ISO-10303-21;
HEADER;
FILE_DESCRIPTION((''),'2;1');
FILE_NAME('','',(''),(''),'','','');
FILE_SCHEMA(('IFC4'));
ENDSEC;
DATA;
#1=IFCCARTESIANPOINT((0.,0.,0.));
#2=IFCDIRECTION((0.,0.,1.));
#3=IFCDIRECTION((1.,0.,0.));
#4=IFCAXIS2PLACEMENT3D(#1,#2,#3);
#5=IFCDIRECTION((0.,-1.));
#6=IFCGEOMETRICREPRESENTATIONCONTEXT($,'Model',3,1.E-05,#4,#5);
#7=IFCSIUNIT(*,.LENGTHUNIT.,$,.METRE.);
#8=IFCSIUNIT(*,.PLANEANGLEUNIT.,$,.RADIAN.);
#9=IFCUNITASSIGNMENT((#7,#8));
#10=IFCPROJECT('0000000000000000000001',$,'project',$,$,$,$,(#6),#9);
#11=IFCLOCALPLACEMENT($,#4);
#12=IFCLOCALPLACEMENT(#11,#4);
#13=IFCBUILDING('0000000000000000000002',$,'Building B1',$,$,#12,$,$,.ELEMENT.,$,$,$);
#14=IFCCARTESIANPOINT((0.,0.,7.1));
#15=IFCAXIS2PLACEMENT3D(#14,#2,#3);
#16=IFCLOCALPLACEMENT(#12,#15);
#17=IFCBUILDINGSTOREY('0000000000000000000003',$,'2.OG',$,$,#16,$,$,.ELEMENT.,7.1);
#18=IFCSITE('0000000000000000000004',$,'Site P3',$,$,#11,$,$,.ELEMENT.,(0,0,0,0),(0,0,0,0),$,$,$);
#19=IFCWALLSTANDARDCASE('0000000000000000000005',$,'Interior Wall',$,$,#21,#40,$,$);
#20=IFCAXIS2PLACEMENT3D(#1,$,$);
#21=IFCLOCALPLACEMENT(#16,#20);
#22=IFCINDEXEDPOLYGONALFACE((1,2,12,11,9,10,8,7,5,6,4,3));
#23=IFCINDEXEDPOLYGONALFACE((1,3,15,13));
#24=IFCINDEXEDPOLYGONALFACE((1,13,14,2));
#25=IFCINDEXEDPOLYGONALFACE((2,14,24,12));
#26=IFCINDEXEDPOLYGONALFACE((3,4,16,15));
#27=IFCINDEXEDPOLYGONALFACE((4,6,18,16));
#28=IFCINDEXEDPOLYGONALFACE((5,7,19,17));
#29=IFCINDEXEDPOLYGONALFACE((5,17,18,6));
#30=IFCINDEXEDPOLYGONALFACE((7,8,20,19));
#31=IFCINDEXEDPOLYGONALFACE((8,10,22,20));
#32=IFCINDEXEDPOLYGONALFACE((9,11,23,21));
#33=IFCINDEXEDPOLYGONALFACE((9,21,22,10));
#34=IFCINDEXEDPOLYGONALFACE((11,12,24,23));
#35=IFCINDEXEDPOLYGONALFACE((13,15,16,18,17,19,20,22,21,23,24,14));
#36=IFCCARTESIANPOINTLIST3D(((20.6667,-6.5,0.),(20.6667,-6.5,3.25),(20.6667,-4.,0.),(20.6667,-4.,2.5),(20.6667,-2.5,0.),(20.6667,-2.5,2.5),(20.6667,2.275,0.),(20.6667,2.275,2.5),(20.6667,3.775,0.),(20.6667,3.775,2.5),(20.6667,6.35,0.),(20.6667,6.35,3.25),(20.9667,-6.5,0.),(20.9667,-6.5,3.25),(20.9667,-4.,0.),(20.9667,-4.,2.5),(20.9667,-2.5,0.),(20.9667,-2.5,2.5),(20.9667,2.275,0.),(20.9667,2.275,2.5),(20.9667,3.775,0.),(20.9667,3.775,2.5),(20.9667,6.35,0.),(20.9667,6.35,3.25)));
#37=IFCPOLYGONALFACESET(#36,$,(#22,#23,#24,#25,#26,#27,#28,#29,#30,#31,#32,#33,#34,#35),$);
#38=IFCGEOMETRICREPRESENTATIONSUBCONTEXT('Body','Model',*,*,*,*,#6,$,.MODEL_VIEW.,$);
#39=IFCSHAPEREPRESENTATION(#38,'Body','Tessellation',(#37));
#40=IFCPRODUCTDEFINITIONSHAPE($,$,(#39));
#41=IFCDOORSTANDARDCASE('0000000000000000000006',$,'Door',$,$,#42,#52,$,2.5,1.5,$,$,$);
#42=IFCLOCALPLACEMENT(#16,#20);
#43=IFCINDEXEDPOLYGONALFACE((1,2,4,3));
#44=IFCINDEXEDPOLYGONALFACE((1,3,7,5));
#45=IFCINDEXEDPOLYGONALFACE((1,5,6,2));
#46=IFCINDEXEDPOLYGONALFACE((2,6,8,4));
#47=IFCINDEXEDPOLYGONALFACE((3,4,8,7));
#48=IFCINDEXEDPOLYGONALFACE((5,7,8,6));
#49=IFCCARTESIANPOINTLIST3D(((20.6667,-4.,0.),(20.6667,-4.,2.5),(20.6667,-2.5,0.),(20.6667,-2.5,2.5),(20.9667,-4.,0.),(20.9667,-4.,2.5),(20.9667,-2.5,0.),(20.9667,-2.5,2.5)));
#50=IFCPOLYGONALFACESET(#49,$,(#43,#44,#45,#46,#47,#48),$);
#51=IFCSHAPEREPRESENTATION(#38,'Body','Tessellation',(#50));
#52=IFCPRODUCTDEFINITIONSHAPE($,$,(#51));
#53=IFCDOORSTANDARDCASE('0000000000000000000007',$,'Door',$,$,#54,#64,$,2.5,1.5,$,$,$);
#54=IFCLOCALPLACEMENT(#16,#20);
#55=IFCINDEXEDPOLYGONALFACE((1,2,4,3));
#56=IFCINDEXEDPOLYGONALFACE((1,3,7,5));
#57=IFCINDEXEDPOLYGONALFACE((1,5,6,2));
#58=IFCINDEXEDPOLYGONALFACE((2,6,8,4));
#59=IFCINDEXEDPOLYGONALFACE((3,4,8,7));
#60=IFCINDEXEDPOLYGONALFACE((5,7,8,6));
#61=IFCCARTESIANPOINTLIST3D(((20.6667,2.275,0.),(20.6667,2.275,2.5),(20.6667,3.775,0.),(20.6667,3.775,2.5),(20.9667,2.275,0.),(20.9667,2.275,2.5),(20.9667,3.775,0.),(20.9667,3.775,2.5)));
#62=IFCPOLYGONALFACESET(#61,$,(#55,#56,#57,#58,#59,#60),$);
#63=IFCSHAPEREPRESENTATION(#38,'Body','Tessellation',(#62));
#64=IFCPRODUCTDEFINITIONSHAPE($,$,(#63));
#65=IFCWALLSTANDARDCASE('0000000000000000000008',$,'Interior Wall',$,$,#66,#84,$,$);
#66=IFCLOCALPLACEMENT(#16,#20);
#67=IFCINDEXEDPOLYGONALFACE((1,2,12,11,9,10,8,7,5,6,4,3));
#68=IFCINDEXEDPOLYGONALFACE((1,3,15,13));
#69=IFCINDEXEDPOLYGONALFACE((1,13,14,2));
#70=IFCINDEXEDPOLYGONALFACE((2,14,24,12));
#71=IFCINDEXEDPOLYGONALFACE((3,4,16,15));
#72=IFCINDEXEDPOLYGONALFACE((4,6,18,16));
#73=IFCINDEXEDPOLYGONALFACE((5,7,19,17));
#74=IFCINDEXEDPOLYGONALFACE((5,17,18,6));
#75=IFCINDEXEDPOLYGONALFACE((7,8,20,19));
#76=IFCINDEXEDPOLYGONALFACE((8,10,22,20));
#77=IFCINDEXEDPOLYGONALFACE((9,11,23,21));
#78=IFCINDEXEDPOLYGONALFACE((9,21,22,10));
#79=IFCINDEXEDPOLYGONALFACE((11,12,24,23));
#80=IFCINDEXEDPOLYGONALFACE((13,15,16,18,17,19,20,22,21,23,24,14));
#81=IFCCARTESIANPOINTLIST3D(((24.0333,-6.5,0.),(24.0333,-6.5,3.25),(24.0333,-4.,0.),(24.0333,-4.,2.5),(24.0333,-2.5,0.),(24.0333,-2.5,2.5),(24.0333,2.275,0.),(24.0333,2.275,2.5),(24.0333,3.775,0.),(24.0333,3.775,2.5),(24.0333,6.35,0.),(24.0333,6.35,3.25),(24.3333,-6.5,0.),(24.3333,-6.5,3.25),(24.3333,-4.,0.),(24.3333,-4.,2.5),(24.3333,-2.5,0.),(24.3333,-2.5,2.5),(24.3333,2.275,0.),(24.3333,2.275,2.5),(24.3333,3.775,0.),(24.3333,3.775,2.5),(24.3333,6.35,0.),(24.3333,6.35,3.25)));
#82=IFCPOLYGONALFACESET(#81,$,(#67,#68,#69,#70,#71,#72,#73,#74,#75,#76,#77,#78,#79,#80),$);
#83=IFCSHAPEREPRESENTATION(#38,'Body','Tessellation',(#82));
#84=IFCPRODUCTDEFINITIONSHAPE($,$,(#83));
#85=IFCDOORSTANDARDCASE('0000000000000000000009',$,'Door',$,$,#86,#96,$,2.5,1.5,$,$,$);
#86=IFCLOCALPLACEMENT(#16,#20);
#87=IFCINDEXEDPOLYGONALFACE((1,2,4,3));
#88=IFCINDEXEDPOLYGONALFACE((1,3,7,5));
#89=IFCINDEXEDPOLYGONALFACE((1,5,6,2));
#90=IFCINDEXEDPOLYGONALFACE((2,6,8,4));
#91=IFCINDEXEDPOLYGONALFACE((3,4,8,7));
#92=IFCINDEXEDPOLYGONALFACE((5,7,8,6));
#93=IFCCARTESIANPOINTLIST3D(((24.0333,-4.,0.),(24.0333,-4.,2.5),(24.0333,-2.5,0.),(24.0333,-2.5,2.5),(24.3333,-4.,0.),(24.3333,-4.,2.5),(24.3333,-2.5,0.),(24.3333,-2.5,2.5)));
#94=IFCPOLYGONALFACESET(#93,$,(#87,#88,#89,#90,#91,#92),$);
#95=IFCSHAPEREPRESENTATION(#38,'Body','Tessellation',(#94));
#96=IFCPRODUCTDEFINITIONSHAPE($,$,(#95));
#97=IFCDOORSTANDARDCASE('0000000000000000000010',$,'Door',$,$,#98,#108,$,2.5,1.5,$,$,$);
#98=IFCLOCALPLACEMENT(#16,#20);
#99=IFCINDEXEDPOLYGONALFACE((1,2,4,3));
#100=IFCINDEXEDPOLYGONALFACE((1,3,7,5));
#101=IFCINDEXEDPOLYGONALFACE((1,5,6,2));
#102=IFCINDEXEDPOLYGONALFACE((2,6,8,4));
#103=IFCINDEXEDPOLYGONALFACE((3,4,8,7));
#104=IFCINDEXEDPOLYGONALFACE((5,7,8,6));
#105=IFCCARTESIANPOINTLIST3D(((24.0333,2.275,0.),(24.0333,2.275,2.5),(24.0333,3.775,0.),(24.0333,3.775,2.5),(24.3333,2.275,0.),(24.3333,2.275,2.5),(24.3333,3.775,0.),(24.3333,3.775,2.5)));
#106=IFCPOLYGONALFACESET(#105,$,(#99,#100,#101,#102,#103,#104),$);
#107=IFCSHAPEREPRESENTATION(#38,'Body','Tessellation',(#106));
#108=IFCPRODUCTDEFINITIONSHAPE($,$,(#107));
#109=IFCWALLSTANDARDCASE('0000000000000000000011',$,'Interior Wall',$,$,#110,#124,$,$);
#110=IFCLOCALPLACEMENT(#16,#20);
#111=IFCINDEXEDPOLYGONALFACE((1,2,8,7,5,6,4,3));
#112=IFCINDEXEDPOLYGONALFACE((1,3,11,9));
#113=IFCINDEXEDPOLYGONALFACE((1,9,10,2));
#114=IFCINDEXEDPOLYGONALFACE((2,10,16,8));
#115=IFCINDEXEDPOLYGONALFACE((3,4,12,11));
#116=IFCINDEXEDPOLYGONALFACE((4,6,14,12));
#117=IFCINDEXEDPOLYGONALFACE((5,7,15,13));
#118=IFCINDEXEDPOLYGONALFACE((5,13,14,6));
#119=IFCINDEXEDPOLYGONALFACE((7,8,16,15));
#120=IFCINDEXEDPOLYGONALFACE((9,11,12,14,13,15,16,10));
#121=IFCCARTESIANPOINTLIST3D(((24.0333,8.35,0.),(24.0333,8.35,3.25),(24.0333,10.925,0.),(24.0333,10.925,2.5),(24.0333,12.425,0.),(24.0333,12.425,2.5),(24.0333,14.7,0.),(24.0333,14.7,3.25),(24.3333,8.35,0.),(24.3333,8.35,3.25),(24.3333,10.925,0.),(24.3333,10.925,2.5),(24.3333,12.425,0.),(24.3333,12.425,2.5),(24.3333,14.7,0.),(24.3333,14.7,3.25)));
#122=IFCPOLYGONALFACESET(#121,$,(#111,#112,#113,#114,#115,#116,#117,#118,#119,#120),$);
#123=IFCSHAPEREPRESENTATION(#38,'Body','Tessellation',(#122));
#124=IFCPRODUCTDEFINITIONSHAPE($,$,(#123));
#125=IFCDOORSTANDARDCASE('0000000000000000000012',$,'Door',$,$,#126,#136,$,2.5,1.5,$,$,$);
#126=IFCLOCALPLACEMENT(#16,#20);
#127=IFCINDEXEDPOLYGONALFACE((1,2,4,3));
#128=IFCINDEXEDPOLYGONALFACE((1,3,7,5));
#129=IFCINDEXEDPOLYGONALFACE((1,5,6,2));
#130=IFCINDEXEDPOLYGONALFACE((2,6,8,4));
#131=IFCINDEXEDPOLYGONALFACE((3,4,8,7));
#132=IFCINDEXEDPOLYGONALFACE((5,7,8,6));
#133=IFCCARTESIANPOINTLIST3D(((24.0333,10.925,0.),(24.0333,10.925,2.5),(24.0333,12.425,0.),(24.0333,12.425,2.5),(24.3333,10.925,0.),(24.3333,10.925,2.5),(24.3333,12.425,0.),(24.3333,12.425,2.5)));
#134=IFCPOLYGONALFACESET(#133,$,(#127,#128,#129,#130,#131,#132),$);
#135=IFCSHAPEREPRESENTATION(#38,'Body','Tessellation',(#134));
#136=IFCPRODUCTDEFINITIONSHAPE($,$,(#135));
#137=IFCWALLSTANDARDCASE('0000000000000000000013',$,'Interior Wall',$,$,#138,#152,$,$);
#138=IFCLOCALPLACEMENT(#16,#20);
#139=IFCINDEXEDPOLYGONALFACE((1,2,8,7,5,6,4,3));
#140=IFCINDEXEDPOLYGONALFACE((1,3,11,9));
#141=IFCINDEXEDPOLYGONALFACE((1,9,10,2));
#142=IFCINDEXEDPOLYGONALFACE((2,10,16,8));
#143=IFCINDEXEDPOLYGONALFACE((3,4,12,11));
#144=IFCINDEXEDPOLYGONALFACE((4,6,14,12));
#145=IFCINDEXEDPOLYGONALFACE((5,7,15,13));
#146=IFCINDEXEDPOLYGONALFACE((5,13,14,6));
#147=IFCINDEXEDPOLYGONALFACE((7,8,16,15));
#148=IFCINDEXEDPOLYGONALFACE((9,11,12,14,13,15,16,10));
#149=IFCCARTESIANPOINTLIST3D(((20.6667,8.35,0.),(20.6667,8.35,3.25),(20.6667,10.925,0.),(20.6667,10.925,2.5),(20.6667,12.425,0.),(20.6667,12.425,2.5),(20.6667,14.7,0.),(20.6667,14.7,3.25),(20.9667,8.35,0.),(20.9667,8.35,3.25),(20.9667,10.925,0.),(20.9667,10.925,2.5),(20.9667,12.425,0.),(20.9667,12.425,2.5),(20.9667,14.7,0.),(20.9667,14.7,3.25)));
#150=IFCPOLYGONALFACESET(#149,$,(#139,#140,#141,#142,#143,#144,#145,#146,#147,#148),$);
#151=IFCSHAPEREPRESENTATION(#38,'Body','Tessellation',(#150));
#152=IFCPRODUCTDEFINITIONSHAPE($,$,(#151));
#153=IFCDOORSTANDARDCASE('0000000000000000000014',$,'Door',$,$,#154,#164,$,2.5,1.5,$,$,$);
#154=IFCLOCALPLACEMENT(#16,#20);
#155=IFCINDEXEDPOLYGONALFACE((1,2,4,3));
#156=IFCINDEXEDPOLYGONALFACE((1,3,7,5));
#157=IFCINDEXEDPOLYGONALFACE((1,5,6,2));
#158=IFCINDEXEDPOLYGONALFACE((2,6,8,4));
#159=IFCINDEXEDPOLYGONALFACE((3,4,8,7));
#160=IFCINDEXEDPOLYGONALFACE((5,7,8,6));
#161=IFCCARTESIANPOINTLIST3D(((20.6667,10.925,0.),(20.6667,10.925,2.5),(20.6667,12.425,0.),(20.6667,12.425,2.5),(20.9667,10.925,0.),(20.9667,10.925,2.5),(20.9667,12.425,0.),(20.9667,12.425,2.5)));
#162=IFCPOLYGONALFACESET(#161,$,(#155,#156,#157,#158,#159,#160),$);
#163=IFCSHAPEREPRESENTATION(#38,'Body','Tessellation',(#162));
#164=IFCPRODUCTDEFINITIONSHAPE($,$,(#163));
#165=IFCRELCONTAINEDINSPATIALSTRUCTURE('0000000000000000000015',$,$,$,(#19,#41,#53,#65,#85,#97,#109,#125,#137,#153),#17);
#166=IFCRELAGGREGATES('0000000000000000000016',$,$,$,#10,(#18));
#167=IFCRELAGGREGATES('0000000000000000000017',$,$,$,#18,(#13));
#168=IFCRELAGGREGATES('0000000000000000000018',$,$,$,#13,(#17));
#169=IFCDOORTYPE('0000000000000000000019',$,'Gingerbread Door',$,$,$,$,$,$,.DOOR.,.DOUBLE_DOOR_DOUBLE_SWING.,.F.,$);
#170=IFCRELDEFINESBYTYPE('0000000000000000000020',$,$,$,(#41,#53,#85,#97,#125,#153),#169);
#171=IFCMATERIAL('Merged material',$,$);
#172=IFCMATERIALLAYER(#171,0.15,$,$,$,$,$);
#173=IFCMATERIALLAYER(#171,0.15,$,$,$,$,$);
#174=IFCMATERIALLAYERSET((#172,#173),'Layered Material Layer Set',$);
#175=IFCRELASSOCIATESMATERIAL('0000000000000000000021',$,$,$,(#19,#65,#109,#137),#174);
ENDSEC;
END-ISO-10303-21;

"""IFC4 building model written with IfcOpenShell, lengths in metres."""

from ifc_helpers import new_model, si_unit, direction, frame, origin_with_axes, place, context, subcontext, project, spatial, polyline, outline, extrude, source, transform, mapped, material, layer, layer_set, layer_usage, type_object, element, fill, save


model = new_model("IFC4")

# Units and contexts
model_context = context("Model", 3, precision=1e-05, world=origin_with_axes(), true_north=direction((0.0, -1.0)))
body_context = subcontext(model_context, "Body", "Model", "MODEL_VIEW")
ifc_project = project(units=[si_unit("LENGTHUNIT", "METRE"), si_unit("PLANEANGLEUNIT", "RADIAN")], contexts=[model_context])

# Site, building, storey
site_placement = place(None, origin_with_axes())
site = spatial("IfcSite", under=ifc_project, at=site_placement, Name="Site P3", CompositionType="ELEMENT", RefLatitude=(0, 0, 0, 0), RefLongitude=(0, 0, 0, 0))
building_placement = place(site_placement, origin_with_axes())
building = spatial("IfcBuilding", under=site, at=building_placement, Name="Building B1", CompositionType="ELEMENT")
storey_placement = place(building_placement, frame((0.0, 0.0, 7.1), z_axis=(0.0, 0.0, 1.0), x_axis=(1.0, 0.0, 0.0)))
storey = spatial("IfcBuildingStorey", under=building, at=storey_placement, Name="2.OG", CompositionType="ELEMENT", Elevation=7.1)

# Shared definitions
ifc_material = material(Name="Merged material")

# Walls, openings, doors
ifc_layer_1 = layer(ifc_material, 0.15)
ifc_layer_2 = layer(ifc_material, 0.15)
ifc_layer_set_1 = layer_set([ifc_layer_1, ifc_layer_2], Name="Layered Material Layer Set")
ifc_layer_usage_1 = layer_usage(ifc_layer_set_1, "AXIS2", "POSITIVE", -0.15)
door_type = type_object("IfcDoorType", Name="Gingerbread Door", OperationType="DOUBLE_DOOR_DOUBLE_SWING", ParameterTakesPrecedence=False, PredefinedType="DOOR")
shared_shape_1 = source(origin_with_axes(), body_context, "Body", "SweptSolid", [
    extrude(outline(polyline([(0.0, 0.0), (0.0, 1.5), (2.5, 1.5), (2.5, 0.0), (0.0, 0.0)])), frame((0.0, -0.15, 0.0), z_axis=(0.0, 1.0, 0.0), x_axis=(0.0, 0.0, 1.0)), (0.0, 0.0, 1.0), 0.3),
])
wall_1_placement = place(storey_placement, frame((20.8167, 6.35, 0.0), z_axis=(0.0, 0.0, 1.0), x_axis=(0.0, -1.0, 0.0)))
wall_1 = element("IfcWallStandardCase", 1, at=wall_1_placement, inside=storey, material=ifc_layer_usage_1, Name="Interior Wall", context=body_context, shape_type="SweptSolid", body=[
    extrude(outline(polyline([(0.0, 0.15), (12.85, 0.15), (12.85, -0.15), (0.0, -0.15), (0.0, 0.15)])), origin_with_axes(), (0.0, 0.0, 1.0), 3.25),
])
opening_1_placement = place(wall_1_placement, frame((8.85, 0.0, 0.0), z_axis=(0.0, 0.0, 1.0), x_axis=(1.0, 0.0, 0.0)))
opening_1 = element("IfcOpeningStandardCase", 2, at=opening_1_placement, cuts=wall_1, context=body_context, shape_type="SweptSolid", body=[
    extrude(outline(polyline([(0.0, 0.0), (0.0, 1.5), (2.5, 1.5), (2.5, 0.0), (0.0, 0.0)])), frame((0.0, -0.15, 0.0), z_axis=(0.0, 1.0, 0.0), x_axis=(0.0, 0.0, 1.0)), (0.0, 0.0, 1.0), 0.3),
])
opening_2_placement = place(wall_1_placement, frame((2.575, 0.0, 0.0), z_axis=(0.0, 0.0, 1.0), x_axis=(1.0, 0.0, 0.0)))
opening_2 = element("IfcOpeningStandardCase", 3, at=opening_2_placement, cuts=wall_1, context=body_context, shape_type="SweptSolid", body=[
    extrude(outline(polyline([(0.0, 0.0), (0.0, 1.5), (2.5, 1.5), (2.5, 0.0), (0.0, 0.0)])), frame((0.0, -0.15, 0.0), z_axis=(0.0, 1.0, 0.0), x_axis=(0.0, 0.0, 1.0)), (0.0, 0.0, 1.0), 0.3),
])
door_1_placement = place(opening_1_placement, origin_with_axes())
door_1 = element("IfcDoorStandardCase", 4, at=door_1_placement, inside=storey, type_object=door_type, Name="Door", OverallHeight=2.5, OverallWidth=1.5, context=body_context, shape_type="MappedRepresentation", body=[
    mapped(shared_shape_1, transform((0.0, 0.0, 0.0))),
])
fill(opening_1, door_1)
door_2_placement = place(opening_2_placement, origin_with_axes())
door_2 = element("IfcDoorStandardCase", 5, at=door_2_placement, inside=storey, type_object=door_type, Name="Door", OverallHeight=2.5, OverallWidth=1.5, context=body_context, shape_type="MappedRepresentation", body=[
    mapped(shared_shape_1, transform((0.0, 0.0, 0.0))),
])
fill(opening_2, door_2)
wall_2_placement = place(storey_placement, frame((24.1833, 6.35, 0.0), z_axis=(0.0, 0.0, 1.0), x_axis=(0.0, -1.0, 0.0)))
wall_2 = element("IfcWallStandardCase", 6, at=wall_2_placement, inside=storey, material=ifc_layer_usage_1, Name="Interior Wall", context=body_context, shape_type="SweptSolid", body=[
    extrude(outline(polyline([(0.0, 0.15), (12.85, 0.15), (12.85, -0.15), (0.0, -0.15), (0.0, 0.15)])), origin_with_axes(), (0.0, 0.0, 1.0), 3.25),
])
opening_3_placement = place(wall_2_placement, frame((8.85, 0.0, 0.0), z_axis=(0.0, 0.0, 1.0), x_axis=(1.0, 0.0, 0.0)))
opening_3 = element("IfcOpeningStandardCase", 7, at=opening_3_placement, cuts=wall_2, context=body_context, shape_type="SweptSolid", body=[
    extrude(outline(polyline([(0.0, 0.0), (0.0, 1.5), (2.5, 1.5), (2.5, 0.0), (0.0, 0.0)])), frame((0.0, -0.15, 0.0), z_axis=(0.0, 1.0, 0.0), x_axis=(0.0, 0.0, 1.0)), (0.0, 0.0, 1.0), 0.3),
])
opening_4_placement = place(wall_2_placement, frame((2.575, 0.0, 0.0), z_axis=(0.0, 0.0, 1.0), x_axis=(1.0, 0.0, 0.0)))
opening_4 = element("IfcOpeningStandardCase", 8, at=opening_4_placement, cuts=wall_2, context=body_context, shape_type="SweptSolid", body=[
    extrude(outline(polyline([(0.0, 0.0), (0.0, 1.5), (2.5, 1.5), (2.5, 0.0), (0.0, 0.0)])), frame((0.0, -0.15, 0.0), z_axis=(0.0, 1.0, 0.0), x_axis=(0.0, 0.0, 1.0)), (0.0, 0.0, 1.0), 0.3),
])
door_3_placement = place(opening_3_placement, origin_with_axes())
door_3 = element("IfcDoorStandardCase", 9, at=door_3_placement, inside=storey, type_object=door_type, Name="Door", OverallHeight=2.5, OverallWidth=1.5, context=body_context, shape_type="MappedRepresentation", body=[
    mapped(shared_shape_1, transform((0.0, 0.0, 0.0))),
])
fill(opening_3, door_3)
door_4_placement = place(opening_4_placement, origin_with_axes())
door_4 = element("IfcDoorStandardCase", 10, at=door_4_placement, inside=storey, type_object=door_type, Name="Door", OverallHeight=2.5, OverallWidth=1.5, context=body_context, shape_type="MappedRepresentation", body=[
    mapped(shared_shape_1, transform((0.0, 0.0, 0.0))),
])
fill(opening_4, door_4)

# Walls, openings, doors
wall_3_placement = place(storey_placement, frame((24.1833, 14.7, 0.0), z_axis=(0.0, 0.0, 1.0), x_axis=(0.0, -1.0, 0.0)))
wall_3 = element("IfcWallStandardCase", 11, at=wall_3_placement, inside=storey, material=ifc_layer_usage_1, Name="Interior Wall", context=body_context, shape_type="SweptSolid", body=[
    extrude(outline(polyline([(0.0, 0.15), (6.35, 0.15), (6.35, -0.15), (0.0, -0.15), (0.0, 0.15)])), origin_with_axes(), (0.0, 0.0, 1.0), 3.25),
])
opening_5_placement = place(wall_3_placement, frame((2.275, 0.0, 0.0), z_axis=(0.0, 0.0, 1.0), x_axis=(1.0, 0.0, 0.0)))
opening_5 = element("IfcOpeningStandardCase", 12, at=opening_5_placement, cuts=wall_3, context=body_context, shape_type="SweptSolid", body=[
    extrude(outline(polyline([(0.0, 0.0), (0.0, 1.5), (2.5, 1.5), (2.5, 0.0), (0.0, 0.0)])), frame((0.0, -0.15, 0.0), z_axis=(0.0, 1.0, 0.0), x_axis=(0.0, 0.0, 1.0)), (0.0, 0.0, 1.0), 0.3),
])
door_5_placement = place(opening_5_placement, origin_with_axes())
door_5 = element("IfcDoorStandardCase", 13, at=door_5_placement, inside=storey, type_object=door_type, Name="Door", OverallHeight=2.5, OverallWidth=1.5, context=body_context, shape_type="MappedRepresentation", body=[
    mapped(shared_shape_1, transform((0.0, 0.0, 0.0))),
])
fill(opening_5, door_5)
wall_4_placement = place(storey_placement, frame((20.8167, 14.7, 0.0), z_axis=(0.0, 0.0, 1.0), x_axis=(0.0, -1.0, 0.0)))
wall_4 = element("IfcWallStandardCase", 14, at=wall_4_placement, inside=storey, material=ifc_layer_usage_1, Name="Interior Wall", context=body_context, shape_type="SweptSolid", body=[
    extrude(outline(polyline([(0.0, 0.15), (6.35, 0.15), (6.35, -0.15), (0.0, -0.15), (0.0, 0.15)])), origin_with_axes(), (0.0, 0.0, 1.0), 3.25),
])
opening_6_placement = place(wall_4_placement, frame((2.275, 0.0, 0.0), z_axis=(0.0, 0.0, 1.0), x_axis=(1.0, 0.0, 0.0)))
opening_6 = element("IfcOpeningStandardCase", 15, at=opening_6_placement, cuts=wall_4, context=body_context, shape_type="SweptSolid", body=[
    extrude(outline(polyline([(0.0, 0.0), (0.0, 1.5), (2.5, 1.5), (2.5, 0.0), (0.0, 0.0)])), frame((0.0, -0.15, 0.0), z_axis=(0.0, 1.0, 0.0), x_axis=(0.0, 0.0, 1.0)), (0.0, 0.0, 1.0), 0.3),
])
door_6_placement = place(opening_6_placement, origin_with_axes())
door_6 = element("IfcDoorStandardCase", 16, at=door_6_placement, inside=storey, type_object=door_type, Name="Door", OverallHeight=2.5, OverallWidth=1.5, context=body_context, shape_type="MappedRepresentation", body=[
    mapped(shared_shape_1, transform((0.0, 0.0, 0.0))),
])
fill(opening_6, door_6)

save(model, "model.ifc")
